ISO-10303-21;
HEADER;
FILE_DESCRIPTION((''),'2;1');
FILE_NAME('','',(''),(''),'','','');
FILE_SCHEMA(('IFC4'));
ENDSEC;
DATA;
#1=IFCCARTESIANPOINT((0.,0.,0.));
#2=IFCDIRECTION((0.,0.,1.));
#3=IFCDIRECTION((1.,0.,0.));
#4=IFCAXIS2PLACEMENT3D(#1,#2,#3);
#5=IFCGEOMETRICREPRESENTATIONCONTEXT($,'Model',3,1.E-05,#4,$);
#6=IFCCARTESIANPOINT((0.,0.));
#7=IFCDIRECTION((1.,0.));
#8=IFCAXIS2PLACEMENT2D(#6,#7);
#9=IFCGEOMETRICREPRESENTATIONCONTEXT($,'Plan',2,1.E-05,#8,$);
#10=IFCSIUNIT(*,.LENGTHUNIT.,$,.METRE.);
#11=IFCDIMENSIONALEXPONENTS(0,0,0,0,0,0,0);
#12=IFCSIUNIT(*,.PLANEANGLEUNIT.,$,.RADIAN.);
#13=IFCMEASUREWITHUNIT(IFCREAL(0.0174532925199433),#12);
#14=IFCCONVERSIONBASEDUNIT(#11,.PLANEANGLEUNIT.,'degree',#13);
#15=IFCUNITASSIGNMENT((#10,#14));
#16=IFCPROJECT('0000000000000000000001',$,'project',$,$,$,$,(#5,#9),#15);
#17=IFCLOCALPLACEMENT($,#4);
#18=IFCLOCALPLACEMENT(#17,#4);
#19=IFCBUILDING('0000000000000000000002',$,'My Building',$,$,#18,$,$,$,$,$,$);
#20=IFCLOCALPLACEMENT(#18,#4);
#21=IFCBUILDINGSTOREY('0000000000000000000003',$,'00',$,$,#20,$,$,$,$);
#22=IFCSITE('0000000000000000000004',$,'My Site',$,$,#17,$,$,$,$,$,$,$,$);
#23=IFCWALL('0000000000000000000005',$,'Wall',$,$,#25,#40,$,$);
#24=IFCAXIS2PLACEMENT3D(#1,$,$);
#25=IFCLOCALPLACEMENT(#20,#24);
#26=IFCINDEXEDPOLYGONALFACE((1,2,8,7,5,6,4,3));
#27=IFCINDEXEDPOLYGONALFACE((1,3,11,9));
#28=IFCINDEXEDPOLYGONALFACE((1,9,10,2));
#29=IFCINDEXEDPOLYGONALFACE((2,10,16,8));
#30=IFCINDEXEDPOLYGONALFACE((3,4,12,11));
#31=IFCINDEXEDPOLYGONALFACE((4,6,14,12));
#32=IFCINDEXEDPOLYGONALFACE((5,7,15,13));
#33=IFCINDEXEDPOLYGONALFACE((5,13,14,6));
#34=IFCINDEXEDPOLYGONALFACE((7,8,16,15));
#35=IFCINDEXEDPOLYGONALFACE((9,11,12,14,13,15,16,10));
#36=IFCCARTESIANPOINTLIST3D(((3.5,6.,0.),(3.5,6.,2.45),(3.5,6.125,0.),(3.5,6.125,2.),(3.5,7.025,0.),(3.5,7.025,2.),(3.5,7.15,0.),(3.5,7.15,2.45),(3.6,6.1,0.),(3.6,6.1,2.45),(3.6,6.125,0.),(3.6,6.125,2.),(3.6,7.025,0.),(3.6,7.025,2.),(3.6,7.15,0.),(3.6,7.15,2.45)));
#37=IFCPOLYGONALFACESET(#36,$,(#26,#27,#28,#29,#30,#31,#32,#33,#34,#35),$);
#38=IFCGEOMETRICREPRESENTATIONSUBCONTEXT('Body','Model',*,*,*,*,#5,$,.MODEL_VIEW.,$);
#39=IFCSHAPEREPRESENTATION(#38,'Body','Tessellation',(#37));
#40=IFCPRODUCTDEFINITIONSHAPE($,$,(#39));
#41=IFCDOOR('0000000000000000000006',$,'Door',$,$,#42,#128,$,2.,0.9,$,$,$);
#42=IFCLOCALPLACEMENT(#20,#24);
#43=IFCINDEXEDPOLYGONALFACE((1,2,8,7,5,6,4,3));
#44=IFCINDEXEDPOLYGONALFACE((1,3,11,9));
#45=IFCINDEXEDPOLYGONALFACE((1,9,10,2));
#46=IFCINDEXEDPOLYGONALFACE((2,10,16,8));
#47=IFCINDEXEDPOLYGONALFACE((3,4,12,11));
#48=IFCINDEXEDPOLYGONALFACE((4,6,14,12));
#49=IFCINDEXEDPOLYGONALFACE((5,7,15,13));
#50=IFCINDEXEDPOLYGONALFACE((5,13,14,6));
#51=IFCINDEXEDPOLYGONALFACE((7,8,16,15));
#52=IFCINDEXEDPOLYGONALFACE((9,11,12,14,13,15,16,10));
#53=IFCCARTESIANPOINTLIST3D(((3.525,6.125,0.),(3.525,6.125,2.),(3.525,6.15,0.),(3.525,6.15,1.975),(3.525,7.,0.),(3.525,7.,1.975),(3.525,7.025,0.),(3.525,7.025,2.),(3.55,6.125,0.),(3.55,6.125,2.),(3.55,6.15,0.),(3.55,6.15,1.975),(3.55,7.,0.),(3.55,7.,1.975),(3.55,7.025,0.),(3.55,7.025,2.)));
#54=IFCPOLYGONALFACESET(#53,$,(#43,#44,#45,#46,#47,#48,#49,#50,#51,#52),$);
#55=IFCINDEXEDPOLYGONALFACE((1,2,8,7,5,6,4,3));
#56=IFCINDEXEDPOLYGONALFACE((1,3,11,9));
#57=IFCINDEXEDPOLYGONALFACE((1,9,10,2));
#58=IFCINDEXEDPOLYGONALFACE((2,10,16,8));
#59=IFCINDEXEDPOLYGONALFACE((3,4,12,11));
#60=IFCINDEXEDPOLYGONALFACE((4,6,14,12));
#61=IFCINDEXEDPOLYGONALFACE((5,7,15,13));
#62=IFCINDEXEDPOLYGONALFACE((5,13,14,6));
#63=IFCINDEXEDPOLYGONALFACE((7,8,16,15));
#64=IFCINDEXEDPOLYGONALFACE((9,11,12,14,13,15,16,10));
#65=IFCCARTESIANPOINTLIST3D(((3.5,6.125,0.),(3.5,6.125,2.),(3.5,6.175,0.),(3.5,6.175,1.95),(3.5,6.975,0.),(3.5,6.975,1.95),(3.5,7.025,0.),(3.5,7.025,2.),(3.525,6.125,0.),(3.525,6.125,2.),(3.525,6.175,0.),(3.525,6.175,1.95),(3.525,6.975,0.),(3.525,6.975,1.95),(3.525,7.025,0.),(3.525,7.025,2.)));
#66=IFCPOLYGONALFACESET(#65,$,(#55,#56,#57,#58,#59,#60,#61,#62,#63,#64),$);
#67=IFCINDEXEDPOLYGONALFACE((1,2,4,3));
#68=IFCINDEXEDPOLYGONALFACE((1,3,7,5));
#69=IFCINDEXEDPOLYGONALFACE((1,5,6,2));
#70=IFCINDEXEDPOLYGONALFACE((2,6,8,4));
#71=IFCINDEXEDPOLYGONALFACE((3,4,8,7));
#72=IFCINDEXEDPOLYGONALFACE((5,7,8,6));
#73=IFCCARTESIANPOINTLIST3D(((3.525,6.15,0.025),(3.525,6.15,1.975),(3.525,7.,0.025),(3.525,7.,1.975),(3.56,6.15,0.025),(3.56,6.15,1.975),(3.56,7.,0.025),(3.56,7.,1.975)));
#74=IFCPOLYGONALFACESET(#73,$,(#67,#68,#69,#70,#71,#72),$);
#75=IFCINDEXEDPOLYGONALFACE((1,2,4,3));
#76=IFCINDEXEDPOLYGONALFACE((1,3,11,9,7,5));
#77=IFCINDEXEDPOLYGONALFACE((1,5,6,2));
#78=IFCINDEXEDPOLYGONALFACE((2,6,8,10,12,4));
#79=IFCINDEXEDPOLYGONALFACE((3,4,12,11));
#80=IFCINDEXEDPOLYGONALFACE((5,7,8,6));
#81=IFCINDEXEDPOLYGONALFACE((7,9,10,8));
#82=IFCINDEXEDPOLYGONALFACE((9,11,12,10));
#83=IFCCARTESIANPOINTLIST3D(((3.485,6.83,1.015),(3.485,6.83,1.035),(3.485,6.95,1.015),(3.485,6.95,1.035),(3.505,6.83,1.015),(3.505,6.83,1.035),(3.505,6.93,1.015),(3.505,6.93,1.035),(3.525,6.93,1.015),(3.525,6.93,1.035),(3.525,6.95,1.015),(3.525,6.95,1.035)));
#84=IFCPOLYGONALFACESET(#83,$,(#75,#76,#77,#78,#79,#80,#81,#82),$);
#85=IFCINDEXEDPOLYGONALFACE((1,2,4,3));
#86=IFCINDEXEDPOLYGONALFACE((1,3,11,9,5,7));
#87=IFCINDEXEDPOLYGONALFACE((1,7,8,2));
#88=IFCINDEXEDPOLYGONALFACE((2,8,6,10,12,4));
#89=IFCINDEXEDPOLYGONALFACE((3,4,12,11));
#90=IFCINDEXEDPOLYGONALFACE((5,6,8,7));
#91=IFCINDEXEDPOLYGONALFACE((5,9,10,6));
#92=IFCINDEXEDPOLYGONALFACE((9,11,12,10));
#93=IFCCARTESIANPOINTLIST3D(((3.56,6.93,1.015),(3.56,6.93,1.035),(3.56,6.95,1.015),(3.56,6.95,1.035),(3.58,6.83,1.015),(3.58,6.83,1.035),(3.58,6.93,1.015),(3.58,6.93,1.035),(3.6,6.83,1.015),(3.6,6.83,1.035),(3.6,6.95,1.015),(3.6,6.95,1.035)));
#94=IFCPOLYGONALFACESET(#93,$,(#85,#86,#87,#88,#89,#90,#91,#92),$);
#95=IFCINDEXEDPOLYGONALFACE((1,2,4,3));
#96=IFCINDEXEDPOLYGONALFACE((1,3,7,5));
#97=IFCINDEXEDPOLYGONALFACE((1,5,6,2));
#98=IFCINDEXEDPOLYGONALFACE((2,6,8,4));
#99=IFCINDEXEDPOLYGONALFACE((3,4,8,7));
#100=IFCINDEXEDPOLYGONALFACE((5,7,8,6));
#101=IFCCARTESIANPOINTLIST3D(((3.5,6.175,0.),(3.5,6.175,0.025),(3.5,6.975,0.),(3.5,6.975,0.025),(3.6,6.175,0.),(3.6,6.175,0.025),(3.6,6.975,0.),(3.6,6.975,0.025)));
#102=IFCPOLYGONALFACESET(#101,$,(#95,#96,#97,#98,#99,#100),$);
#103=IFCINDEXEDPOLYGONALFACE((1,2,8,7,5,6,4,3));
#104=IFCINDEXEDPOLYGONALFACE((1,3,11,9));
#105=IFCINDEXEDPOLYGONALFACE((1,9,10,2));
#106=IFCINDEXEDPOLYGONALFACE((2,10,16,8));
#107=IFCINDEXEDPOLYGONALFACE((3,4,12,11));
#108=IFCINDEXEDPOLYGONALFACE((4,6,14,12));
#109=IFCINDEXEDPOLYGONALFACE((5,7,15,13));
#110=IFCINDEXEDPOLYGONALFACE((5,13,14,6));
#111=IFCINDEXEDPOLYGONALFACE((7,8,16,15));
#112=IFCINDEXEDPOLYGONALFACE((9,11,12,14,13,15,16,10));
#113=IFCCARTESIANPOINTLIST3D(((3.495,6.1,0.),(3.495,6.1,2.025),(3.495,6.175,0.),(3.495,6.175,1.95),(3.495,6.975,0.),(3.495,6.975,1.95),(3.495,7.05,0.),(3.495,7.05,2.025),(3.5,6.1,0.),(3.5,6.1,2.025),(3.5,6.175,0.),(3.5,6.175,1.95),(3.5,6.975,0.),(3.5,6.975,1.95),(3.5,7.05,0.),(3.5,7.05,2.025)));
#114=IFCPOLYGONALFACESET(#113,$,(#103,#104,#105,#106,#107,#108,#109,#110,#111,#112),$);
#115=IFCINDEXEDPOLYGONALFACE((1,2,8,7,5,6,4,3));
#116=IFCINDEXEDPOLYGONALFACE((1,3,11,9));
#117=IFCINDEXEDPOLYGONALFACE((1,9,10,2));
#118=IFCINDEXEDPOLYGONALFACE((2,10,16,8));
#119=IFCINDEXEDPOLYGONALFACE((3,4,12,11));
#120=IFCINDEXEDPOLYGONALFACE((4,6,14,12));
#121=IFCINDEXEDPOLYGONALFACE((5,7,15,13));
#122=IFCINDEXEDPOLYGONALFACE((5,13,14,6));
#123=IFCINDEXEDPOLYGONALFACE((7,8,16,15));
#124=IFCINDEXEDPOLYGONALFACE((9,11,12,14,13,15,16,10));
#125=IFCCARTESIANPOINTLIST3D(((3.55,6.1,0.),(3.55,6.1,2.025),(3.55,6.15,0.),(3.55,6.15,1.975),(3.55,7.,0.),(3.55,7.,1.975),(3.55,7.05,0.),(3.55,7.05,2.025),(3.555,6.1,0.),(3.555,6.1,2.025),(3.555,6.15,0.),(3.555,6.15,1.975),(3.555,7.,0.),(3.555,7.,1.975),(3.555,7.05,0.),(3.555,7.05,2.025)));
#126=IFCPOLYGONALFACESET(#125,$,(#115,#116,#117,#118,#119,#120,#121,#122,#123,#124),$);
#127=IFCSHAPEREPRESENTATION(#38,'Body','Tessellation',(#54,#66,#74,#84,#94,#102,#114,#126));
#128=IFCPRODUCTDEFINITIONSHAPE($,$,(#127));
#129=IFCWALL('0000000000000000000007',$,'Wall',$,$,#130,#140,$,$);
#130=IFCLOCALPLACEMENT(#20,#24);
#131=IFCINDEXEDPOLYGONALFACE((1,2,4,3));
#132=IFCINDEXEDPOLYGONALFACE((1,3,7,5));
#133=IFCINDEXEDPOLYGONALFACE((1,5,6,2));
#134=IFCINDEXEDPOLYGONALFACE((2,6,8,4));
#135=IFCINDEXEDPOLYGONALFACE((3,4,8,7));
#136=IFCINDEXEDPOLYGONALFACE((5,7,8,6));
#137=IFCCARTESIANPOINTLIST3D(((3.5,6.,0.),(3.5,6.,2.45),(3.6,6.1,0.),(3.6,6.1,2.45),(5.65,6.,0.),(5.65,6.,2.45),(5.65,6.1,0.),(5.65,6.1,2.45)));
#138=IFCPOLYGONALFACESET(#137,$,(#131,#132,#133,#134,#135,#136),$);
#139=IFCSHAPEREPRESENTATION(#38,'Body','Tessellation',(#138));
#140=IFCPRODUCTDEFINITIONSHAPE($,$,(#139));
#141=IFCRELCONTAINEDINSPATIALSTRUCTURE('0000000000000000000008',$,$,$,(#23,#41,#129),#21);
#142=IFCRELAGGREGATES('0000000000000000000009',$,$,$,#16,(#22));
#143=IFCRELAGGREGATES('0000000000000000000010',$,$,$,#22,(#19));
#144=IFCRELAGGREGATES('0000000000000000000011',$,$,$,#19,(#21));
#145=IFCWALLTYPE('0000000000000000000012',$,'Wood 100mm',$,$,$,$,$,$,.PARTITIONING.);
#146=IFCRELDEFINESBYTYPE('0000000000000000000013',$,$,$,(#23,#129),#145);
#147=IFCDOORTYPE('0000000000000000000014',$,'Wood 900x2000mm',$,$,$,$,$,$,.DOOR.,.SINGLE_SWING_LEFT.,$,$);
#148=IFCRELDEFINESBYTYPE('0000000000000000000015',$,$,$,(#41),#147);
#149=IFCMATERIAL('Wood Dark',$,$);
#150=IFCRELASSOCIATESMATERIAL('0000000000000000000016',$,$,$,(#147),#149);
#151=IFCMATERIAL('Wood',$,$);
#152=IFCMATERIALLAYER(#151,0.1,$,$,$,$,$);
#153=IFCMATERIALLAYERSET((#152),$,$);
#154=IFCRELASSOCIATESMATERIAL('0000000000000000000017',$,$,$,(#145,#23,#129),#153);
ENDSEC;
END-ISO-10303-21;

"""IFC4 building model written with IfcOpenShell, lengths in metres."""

from ifc_helpers import new_model, entity, si_unit, converted_unit, frame, origin_with_axes, origin_2d_with_axis, place, context, subcontext, project, spatial, line, indexed_curve, outline, extrude, clip, halfspace, shape, source, transform, mapped, material, layer, layer_set, layer_usage, type_object, type_shapes, element, fill, save


model = new_model("IFC4")

# Units and contexts
model_context = context("Model", 3, precision=1e-05, world=origin_with_axes())
plan_context = context("Plan", 2, precision=1e-05, world=origin_2d_with_axis())
body_context_1 = subcontext(model_context, "Body", "Model", "MODEL_VIEW")
body_context_2 = subcontext(plan_context, "Body", "Plan", "PLAN_VIEW")
ifc_project = project(units=[si_unit("LENGTHUNIT", "METRE"), converted_unit("PLANEANGLEUNIT", "degree", entity("IfcReal", 0.0174532925199433), si_unit("PLANEANGLEUNIT", "RADIAN"), dimensions=[0, 0, 0, 0, 0, 0, 0])], contexts=[model_context, plan_context])

# Site, building, storey
site_placement = place(None, origin_with_axes())
site = spatial("IfcSite", under=ifc_project, at=site_placement, Name="My Site")
building_placement = place(site_placement, origin_with_axes())
building = spatial("IfcBuilding", under=site, at=building_placement, Name="My Building")
storey_placement = place(building_placement, origin_with_axes())
storey = spatial("IfcBuildingStorey", under=building, at=storey_placement, Name="00")

# Shared definitions
ifc_material_1 = material(Name="Wood")
ifc_material_2 = material(Name="Wood Dark")

# Shared definitions
shared_shape_1 = source(origin_with_axes(), body_context_1, "Body", "SweptSolid", [
    extrude(outline(indexed_curve([(0.0, 0.0), (0.9, 0.0), (0.9, 2.0), (0.0, 2.0)], segments=[line(1, 2, 3, 4, 1)])), frame((0.0, -0.6, 0.0), z_axis=(0.0, -1.0, 0.0), x_axis=(1.0, 0.0, 0.0)), (0.0, 0.0, -1.0), 1.2),
])
door_type_1 = type_object("IfcDoorType", Name="Wood 900x2000mm", OperationType="SINGLE_SWING_LEFT", PredefinedType="DOOR", material=ifc_material_2)
shared_shape_2 = source(origin_with_axes(), body_context_1, "Body", "SweptSolid", [
    extrude(outline(indexed_curve([(0.0, 0.0), (0.0, 2.0), (0.9, 2.0), (0.9, 0.0), (0.875, 0.0), (0.875, 1.975), (0.025, 1.975), (0.025, 0.0)], segments=[line(1, 2, 3, 4, 5, 6, 7, 8, 1)])), frame((0.0, 0.025, 0.0), z_axis=(0.0, -1.0, 0.0), x_axis=(1.0, 0.0, 0.0)), (0.0, 0.0, -1.0), 0.025),
    extrude(outline(indexed_curve([(0.0, 0.0), (0.0, 2.0), (0.9, 2.0), (0.9, 0.0), (0.85, 0.0), (0.85, 1.95), (0.05, 1.95), (0.05, 0.0)], segments=[line(1, 2, 3, 4, 5, 6, 7, 8, 1)])), frame((0.0, 0.0, 0.0), z_axis=(0.0, -1.0, 0.0), x_axis=(1.0, 0.0, 0.0)), (0.0, 0.0, -1.0), 0.025),
    extrude(outline(indexed_curve([(0.0, 0.0), (0.85, 0.0), (0.85, 0.035), (0.0, 0.035)], segments=[line(1, 2, 3, 4, 1)])), frame((0.025, 0.025, 0.025), z_axis=(0.0, 0.0, 1.0), x_axis=(1.0, 0.0, 0.0)), (0.0, 0.0, 1.0), 1.95),
    extrude(outline(indexed_curve([(0.0, 0.0), (0.0, -0.04), (0.12, -0.04), (0.12, -0.02), (0.02, -0.02), (0.02, 0.0)], segments=[line(1, 2, 3, 4, 5, 6, 1)])), frame((0.075, 0.025, 1.015), z_axis=(0.0, 0.0, 1.0), x_axis=(1.0, 0.0, 0.0)), (0.0, 0.0, 1.0), 0.02),
    extrude(outline(indexed_curve([(0.0, 0.0), (0.0, 0.04), (0.12, 0.04), (0.12, 0.02), (0.02, 0.02), (0.02, 0.0)], segments=[line(1, 2, 3, 4, 5, 6, 1)])), frame((0.075, 0.06, 1.015), z_axis=(0.0, 0.0, 1.0), x_axis=(1.0, 0.0, 0.0)), (0.0, 0.0, 1.0), 0.02),
    extrude(outline(indexed_curve([(0.0, 0.0), (0.8, 0.0), (0.8, 0.1), (0.0, 0.1)], segments=[line(1, 2, 3, 4, 1)])), frame((0.05, 0.0, 0.0), z_axis=(0.0, 0.0, 1.0), x_axis=(1.0, 0.0, 0.0)), (0.0, 0.0, 1.0), 0.025),
    extrude(outline(indexed_curve([(0.0, 0.0), (0.0, 2.025), (0.95, 2.025), (0.95, 0.0), (0.875, 0.0), (0.875, 1.95), (0.075, 1.95), (0.075, 0.0)], segments=[line(1, 2, 3, 4, 5, 6, 7, 8, 1)])), frame((-0.025, -0.005, 0.0), z_axis=(0.0, -1.0, 0.0), x_axis=(1.0, 0.0, 0.0)), (0.0, 0.0, -1.0), 0.005),
    extrude(outline(indexed_curve([(0.0, 0.0), (0.0, 2.025), (0.95, 2.025), (0.95, 0.0), (0.9, 0.0), (0.9, 1.975), (0.05, 1.975), (0.05, 0.0)], segments=[line(1, 2, 3, 4, 5, 6, 7, 8, 1)])), frame((-0.025, 0.05, 0.0), z_axis=(0.0, -1.0, 0.0), x_axis=(1.0, 0.0, 0.0)), (0.0, 0.0, -1.0), 0.005),
])
shared_shape_3 = source(origin_with_axes(), body_context_2, "Body", "Curve2D", [
    entity("IfcIndexedPolyCurve", entity("IfcCartesianPointList2D", [[0.0, 0.0], [0.0, 0.05], [0.025, 0.05], [0.025, 0.025], [0.05, 0.025], [0.05, 0.0]]), [entity("IfcLineIndex", [1, 2, 3, 4, 5, 6, 1])]),
    entity("IfcIndexedPolyCurve", entity("IfcCartesianPointList2D", [[0.9, 0.0], [0.9, 0.05], [0.875, 0.05], [0.875, 0.025], [0.85, 0.025], [0.85, 0.0]]), [entity("IfcLineIndex", [1, 2, 3, 4, 5, 6, 1])]),
    entity("IfcTrimmedCurve", entity("IfcEllipse", entity("IfcAxis2Placement2D", entity("IfcCartesianPoint", [0.84, 0.05]), entity("IfcDirection", [1.0, 0.0])), 0.815, 0.85), [entity("IfcCartesianPoint", [0.84, 0.9])], [entity("IfcCartesianPoint", [0.025, 0.05])], True, "CARTESIAN"),
    entity("IfcIndexedPolyCurve", entity("IfcCartesianPointList2D", [[0.875, 0.05], [0.84, 0.05], [0.84, 0.9], [0.875, 0.9]]), [entity("IfcLineIndex", [1, 2, 3, 4, 1])]),
])
type_shapes(door_type_1, [shared_shape_2, shared_shape_3])

# Wall, opening, door
ifc_layer_1 = layer(ifc_material_1, 0.1)
ifc_layer_set_1 = layer_set([ifc_layer_1])
ifc_layer_usage_1 = layer_usage(ifc_layer_set_1, "AXIS2", "POSITIVE", 0.0)
wall_type_1 = type_object("IfcWallType", Name="Wood 100mm", PredefinedType="PARTITIONING", material=ifc_layer_set_1)
wall_1_placement = place(storey_placement, frame((3.5, 7.15, 0.0), z_axis=(0.0, 0.0, 1.0), x_axis=(0.0, -1.0, 0.0)))
wall_1 = element("IfcWall", 1, at=wall_1_placement, inside=storey, type_object=wall_type_1, material=ifc_layer_usage_1, Name="Wall", context=body_context_1, shape_type="Clipping", body=[
    clip(extrude(outline(indexed_curve([(0.0, 0.0), (0.0, 0.1), (1.15, 0.1), (1.15, 0.0), (0.0, 0.0)], self_intersect=False)), origin_with_axes(), (0.0, 0.0, 1.0), 2.45), halfspace(frame((1.15, 0.0, 0.0), z_axis=(0.707106, 0.707107, 0.0), x_axis=(0.707107, -0.707106, 0.0)), False)),
])
opening_1_placement = place(wall_1_placement, frame((0.125, 0.0, 0.0), z_axis=(0.0, 0.0, 1.0), x_axis=(1.0, 0.0, 0.0)))
opening_1 = element("IfcOpeningElement", 2, at=opening_1_placement, cuts=wall_1, PredefinedType="OPENING", context=body_context_1, shape_type="MappedRepresentation", body=[
    mapped(shared_shape_1, transform((0.0, 0.0, 0.0), x_axis=(1.0, 0.0, 0.0), y_axis=(0.0, 1.0, 0.0), z_axis=(0.0, 0.0, 1.0), scale=1.0)),
])
door_1_placement = place(opening_1_placement, frame((0.0, 0.0, 0.0), z_axis=(0.0, 0.0, 1.0), x_axis=(1.0, 0.0, 0.0)))
door_1 = element("IfcDoor", 3, at=door_1_placement, inside=storey, type_object=door_type_1, Name="Door", OverallHeight=2.0, OverallWidth=0.9, shapes=[
    shape(body_context_1, "Body", "MappedRepresentation", [mapped(shared_shape_2, transform((0.0, 0.0, 0.0), x_axis=(1.0, 0.0, 0.0), y_axis=(0.0, 1.0, 0.0), z_axis=(0.0, 0.0, 1.0), scale=1.0))]),
    shape(body_context_2, "Body", "MappedRepresentation", [mapped(shared_shape_3, transform((0.0, 0.0, 0.0), x_axis=(1.0, 0.0, 0.0), y_axis=(0.0, 1.0, 0.0), z_axis=(0.0, 0.0, 1.0), scale=1.0))]),
])
fill(opening_1, door_1)

# Wall
ifc_layer_usage_2 = layer_usage(ifc_layer_set_1, "AXIS2", "POSITIVE", 0.0)
wall_2_placement = place(storey_placement, frame((3.5, 6.0, 0.0), z_axis=(0.0, 0.0, 1.0), x_axis=(1.0, 0.0, 0.0)))
element("IfcWall", 4, at=wall_2_placement, inside=storey, type_object=wall_type_1, material=ifc_layer_usage_2, Name="Wall", context=body_context_1, shape_type="Clipping", body=[
    clip(extrude(outline(indexed_curve([(0.0, 0.0), (0.0, 0.1), (2.15, 0.1), (2.15, 0.0), (0.0, 0.0)], self_intersect=False)), origin_with_axes(), (0.0, 0.0, 1.0), 2.45), halfspace(frame((0.0, 0.0, 0.0), z_axis=(-0.707108, 0.707106, 0.0), x_axis=(0.707106, 0.707108, 0.0)), False)),
])

save(model, "model.ifc")
